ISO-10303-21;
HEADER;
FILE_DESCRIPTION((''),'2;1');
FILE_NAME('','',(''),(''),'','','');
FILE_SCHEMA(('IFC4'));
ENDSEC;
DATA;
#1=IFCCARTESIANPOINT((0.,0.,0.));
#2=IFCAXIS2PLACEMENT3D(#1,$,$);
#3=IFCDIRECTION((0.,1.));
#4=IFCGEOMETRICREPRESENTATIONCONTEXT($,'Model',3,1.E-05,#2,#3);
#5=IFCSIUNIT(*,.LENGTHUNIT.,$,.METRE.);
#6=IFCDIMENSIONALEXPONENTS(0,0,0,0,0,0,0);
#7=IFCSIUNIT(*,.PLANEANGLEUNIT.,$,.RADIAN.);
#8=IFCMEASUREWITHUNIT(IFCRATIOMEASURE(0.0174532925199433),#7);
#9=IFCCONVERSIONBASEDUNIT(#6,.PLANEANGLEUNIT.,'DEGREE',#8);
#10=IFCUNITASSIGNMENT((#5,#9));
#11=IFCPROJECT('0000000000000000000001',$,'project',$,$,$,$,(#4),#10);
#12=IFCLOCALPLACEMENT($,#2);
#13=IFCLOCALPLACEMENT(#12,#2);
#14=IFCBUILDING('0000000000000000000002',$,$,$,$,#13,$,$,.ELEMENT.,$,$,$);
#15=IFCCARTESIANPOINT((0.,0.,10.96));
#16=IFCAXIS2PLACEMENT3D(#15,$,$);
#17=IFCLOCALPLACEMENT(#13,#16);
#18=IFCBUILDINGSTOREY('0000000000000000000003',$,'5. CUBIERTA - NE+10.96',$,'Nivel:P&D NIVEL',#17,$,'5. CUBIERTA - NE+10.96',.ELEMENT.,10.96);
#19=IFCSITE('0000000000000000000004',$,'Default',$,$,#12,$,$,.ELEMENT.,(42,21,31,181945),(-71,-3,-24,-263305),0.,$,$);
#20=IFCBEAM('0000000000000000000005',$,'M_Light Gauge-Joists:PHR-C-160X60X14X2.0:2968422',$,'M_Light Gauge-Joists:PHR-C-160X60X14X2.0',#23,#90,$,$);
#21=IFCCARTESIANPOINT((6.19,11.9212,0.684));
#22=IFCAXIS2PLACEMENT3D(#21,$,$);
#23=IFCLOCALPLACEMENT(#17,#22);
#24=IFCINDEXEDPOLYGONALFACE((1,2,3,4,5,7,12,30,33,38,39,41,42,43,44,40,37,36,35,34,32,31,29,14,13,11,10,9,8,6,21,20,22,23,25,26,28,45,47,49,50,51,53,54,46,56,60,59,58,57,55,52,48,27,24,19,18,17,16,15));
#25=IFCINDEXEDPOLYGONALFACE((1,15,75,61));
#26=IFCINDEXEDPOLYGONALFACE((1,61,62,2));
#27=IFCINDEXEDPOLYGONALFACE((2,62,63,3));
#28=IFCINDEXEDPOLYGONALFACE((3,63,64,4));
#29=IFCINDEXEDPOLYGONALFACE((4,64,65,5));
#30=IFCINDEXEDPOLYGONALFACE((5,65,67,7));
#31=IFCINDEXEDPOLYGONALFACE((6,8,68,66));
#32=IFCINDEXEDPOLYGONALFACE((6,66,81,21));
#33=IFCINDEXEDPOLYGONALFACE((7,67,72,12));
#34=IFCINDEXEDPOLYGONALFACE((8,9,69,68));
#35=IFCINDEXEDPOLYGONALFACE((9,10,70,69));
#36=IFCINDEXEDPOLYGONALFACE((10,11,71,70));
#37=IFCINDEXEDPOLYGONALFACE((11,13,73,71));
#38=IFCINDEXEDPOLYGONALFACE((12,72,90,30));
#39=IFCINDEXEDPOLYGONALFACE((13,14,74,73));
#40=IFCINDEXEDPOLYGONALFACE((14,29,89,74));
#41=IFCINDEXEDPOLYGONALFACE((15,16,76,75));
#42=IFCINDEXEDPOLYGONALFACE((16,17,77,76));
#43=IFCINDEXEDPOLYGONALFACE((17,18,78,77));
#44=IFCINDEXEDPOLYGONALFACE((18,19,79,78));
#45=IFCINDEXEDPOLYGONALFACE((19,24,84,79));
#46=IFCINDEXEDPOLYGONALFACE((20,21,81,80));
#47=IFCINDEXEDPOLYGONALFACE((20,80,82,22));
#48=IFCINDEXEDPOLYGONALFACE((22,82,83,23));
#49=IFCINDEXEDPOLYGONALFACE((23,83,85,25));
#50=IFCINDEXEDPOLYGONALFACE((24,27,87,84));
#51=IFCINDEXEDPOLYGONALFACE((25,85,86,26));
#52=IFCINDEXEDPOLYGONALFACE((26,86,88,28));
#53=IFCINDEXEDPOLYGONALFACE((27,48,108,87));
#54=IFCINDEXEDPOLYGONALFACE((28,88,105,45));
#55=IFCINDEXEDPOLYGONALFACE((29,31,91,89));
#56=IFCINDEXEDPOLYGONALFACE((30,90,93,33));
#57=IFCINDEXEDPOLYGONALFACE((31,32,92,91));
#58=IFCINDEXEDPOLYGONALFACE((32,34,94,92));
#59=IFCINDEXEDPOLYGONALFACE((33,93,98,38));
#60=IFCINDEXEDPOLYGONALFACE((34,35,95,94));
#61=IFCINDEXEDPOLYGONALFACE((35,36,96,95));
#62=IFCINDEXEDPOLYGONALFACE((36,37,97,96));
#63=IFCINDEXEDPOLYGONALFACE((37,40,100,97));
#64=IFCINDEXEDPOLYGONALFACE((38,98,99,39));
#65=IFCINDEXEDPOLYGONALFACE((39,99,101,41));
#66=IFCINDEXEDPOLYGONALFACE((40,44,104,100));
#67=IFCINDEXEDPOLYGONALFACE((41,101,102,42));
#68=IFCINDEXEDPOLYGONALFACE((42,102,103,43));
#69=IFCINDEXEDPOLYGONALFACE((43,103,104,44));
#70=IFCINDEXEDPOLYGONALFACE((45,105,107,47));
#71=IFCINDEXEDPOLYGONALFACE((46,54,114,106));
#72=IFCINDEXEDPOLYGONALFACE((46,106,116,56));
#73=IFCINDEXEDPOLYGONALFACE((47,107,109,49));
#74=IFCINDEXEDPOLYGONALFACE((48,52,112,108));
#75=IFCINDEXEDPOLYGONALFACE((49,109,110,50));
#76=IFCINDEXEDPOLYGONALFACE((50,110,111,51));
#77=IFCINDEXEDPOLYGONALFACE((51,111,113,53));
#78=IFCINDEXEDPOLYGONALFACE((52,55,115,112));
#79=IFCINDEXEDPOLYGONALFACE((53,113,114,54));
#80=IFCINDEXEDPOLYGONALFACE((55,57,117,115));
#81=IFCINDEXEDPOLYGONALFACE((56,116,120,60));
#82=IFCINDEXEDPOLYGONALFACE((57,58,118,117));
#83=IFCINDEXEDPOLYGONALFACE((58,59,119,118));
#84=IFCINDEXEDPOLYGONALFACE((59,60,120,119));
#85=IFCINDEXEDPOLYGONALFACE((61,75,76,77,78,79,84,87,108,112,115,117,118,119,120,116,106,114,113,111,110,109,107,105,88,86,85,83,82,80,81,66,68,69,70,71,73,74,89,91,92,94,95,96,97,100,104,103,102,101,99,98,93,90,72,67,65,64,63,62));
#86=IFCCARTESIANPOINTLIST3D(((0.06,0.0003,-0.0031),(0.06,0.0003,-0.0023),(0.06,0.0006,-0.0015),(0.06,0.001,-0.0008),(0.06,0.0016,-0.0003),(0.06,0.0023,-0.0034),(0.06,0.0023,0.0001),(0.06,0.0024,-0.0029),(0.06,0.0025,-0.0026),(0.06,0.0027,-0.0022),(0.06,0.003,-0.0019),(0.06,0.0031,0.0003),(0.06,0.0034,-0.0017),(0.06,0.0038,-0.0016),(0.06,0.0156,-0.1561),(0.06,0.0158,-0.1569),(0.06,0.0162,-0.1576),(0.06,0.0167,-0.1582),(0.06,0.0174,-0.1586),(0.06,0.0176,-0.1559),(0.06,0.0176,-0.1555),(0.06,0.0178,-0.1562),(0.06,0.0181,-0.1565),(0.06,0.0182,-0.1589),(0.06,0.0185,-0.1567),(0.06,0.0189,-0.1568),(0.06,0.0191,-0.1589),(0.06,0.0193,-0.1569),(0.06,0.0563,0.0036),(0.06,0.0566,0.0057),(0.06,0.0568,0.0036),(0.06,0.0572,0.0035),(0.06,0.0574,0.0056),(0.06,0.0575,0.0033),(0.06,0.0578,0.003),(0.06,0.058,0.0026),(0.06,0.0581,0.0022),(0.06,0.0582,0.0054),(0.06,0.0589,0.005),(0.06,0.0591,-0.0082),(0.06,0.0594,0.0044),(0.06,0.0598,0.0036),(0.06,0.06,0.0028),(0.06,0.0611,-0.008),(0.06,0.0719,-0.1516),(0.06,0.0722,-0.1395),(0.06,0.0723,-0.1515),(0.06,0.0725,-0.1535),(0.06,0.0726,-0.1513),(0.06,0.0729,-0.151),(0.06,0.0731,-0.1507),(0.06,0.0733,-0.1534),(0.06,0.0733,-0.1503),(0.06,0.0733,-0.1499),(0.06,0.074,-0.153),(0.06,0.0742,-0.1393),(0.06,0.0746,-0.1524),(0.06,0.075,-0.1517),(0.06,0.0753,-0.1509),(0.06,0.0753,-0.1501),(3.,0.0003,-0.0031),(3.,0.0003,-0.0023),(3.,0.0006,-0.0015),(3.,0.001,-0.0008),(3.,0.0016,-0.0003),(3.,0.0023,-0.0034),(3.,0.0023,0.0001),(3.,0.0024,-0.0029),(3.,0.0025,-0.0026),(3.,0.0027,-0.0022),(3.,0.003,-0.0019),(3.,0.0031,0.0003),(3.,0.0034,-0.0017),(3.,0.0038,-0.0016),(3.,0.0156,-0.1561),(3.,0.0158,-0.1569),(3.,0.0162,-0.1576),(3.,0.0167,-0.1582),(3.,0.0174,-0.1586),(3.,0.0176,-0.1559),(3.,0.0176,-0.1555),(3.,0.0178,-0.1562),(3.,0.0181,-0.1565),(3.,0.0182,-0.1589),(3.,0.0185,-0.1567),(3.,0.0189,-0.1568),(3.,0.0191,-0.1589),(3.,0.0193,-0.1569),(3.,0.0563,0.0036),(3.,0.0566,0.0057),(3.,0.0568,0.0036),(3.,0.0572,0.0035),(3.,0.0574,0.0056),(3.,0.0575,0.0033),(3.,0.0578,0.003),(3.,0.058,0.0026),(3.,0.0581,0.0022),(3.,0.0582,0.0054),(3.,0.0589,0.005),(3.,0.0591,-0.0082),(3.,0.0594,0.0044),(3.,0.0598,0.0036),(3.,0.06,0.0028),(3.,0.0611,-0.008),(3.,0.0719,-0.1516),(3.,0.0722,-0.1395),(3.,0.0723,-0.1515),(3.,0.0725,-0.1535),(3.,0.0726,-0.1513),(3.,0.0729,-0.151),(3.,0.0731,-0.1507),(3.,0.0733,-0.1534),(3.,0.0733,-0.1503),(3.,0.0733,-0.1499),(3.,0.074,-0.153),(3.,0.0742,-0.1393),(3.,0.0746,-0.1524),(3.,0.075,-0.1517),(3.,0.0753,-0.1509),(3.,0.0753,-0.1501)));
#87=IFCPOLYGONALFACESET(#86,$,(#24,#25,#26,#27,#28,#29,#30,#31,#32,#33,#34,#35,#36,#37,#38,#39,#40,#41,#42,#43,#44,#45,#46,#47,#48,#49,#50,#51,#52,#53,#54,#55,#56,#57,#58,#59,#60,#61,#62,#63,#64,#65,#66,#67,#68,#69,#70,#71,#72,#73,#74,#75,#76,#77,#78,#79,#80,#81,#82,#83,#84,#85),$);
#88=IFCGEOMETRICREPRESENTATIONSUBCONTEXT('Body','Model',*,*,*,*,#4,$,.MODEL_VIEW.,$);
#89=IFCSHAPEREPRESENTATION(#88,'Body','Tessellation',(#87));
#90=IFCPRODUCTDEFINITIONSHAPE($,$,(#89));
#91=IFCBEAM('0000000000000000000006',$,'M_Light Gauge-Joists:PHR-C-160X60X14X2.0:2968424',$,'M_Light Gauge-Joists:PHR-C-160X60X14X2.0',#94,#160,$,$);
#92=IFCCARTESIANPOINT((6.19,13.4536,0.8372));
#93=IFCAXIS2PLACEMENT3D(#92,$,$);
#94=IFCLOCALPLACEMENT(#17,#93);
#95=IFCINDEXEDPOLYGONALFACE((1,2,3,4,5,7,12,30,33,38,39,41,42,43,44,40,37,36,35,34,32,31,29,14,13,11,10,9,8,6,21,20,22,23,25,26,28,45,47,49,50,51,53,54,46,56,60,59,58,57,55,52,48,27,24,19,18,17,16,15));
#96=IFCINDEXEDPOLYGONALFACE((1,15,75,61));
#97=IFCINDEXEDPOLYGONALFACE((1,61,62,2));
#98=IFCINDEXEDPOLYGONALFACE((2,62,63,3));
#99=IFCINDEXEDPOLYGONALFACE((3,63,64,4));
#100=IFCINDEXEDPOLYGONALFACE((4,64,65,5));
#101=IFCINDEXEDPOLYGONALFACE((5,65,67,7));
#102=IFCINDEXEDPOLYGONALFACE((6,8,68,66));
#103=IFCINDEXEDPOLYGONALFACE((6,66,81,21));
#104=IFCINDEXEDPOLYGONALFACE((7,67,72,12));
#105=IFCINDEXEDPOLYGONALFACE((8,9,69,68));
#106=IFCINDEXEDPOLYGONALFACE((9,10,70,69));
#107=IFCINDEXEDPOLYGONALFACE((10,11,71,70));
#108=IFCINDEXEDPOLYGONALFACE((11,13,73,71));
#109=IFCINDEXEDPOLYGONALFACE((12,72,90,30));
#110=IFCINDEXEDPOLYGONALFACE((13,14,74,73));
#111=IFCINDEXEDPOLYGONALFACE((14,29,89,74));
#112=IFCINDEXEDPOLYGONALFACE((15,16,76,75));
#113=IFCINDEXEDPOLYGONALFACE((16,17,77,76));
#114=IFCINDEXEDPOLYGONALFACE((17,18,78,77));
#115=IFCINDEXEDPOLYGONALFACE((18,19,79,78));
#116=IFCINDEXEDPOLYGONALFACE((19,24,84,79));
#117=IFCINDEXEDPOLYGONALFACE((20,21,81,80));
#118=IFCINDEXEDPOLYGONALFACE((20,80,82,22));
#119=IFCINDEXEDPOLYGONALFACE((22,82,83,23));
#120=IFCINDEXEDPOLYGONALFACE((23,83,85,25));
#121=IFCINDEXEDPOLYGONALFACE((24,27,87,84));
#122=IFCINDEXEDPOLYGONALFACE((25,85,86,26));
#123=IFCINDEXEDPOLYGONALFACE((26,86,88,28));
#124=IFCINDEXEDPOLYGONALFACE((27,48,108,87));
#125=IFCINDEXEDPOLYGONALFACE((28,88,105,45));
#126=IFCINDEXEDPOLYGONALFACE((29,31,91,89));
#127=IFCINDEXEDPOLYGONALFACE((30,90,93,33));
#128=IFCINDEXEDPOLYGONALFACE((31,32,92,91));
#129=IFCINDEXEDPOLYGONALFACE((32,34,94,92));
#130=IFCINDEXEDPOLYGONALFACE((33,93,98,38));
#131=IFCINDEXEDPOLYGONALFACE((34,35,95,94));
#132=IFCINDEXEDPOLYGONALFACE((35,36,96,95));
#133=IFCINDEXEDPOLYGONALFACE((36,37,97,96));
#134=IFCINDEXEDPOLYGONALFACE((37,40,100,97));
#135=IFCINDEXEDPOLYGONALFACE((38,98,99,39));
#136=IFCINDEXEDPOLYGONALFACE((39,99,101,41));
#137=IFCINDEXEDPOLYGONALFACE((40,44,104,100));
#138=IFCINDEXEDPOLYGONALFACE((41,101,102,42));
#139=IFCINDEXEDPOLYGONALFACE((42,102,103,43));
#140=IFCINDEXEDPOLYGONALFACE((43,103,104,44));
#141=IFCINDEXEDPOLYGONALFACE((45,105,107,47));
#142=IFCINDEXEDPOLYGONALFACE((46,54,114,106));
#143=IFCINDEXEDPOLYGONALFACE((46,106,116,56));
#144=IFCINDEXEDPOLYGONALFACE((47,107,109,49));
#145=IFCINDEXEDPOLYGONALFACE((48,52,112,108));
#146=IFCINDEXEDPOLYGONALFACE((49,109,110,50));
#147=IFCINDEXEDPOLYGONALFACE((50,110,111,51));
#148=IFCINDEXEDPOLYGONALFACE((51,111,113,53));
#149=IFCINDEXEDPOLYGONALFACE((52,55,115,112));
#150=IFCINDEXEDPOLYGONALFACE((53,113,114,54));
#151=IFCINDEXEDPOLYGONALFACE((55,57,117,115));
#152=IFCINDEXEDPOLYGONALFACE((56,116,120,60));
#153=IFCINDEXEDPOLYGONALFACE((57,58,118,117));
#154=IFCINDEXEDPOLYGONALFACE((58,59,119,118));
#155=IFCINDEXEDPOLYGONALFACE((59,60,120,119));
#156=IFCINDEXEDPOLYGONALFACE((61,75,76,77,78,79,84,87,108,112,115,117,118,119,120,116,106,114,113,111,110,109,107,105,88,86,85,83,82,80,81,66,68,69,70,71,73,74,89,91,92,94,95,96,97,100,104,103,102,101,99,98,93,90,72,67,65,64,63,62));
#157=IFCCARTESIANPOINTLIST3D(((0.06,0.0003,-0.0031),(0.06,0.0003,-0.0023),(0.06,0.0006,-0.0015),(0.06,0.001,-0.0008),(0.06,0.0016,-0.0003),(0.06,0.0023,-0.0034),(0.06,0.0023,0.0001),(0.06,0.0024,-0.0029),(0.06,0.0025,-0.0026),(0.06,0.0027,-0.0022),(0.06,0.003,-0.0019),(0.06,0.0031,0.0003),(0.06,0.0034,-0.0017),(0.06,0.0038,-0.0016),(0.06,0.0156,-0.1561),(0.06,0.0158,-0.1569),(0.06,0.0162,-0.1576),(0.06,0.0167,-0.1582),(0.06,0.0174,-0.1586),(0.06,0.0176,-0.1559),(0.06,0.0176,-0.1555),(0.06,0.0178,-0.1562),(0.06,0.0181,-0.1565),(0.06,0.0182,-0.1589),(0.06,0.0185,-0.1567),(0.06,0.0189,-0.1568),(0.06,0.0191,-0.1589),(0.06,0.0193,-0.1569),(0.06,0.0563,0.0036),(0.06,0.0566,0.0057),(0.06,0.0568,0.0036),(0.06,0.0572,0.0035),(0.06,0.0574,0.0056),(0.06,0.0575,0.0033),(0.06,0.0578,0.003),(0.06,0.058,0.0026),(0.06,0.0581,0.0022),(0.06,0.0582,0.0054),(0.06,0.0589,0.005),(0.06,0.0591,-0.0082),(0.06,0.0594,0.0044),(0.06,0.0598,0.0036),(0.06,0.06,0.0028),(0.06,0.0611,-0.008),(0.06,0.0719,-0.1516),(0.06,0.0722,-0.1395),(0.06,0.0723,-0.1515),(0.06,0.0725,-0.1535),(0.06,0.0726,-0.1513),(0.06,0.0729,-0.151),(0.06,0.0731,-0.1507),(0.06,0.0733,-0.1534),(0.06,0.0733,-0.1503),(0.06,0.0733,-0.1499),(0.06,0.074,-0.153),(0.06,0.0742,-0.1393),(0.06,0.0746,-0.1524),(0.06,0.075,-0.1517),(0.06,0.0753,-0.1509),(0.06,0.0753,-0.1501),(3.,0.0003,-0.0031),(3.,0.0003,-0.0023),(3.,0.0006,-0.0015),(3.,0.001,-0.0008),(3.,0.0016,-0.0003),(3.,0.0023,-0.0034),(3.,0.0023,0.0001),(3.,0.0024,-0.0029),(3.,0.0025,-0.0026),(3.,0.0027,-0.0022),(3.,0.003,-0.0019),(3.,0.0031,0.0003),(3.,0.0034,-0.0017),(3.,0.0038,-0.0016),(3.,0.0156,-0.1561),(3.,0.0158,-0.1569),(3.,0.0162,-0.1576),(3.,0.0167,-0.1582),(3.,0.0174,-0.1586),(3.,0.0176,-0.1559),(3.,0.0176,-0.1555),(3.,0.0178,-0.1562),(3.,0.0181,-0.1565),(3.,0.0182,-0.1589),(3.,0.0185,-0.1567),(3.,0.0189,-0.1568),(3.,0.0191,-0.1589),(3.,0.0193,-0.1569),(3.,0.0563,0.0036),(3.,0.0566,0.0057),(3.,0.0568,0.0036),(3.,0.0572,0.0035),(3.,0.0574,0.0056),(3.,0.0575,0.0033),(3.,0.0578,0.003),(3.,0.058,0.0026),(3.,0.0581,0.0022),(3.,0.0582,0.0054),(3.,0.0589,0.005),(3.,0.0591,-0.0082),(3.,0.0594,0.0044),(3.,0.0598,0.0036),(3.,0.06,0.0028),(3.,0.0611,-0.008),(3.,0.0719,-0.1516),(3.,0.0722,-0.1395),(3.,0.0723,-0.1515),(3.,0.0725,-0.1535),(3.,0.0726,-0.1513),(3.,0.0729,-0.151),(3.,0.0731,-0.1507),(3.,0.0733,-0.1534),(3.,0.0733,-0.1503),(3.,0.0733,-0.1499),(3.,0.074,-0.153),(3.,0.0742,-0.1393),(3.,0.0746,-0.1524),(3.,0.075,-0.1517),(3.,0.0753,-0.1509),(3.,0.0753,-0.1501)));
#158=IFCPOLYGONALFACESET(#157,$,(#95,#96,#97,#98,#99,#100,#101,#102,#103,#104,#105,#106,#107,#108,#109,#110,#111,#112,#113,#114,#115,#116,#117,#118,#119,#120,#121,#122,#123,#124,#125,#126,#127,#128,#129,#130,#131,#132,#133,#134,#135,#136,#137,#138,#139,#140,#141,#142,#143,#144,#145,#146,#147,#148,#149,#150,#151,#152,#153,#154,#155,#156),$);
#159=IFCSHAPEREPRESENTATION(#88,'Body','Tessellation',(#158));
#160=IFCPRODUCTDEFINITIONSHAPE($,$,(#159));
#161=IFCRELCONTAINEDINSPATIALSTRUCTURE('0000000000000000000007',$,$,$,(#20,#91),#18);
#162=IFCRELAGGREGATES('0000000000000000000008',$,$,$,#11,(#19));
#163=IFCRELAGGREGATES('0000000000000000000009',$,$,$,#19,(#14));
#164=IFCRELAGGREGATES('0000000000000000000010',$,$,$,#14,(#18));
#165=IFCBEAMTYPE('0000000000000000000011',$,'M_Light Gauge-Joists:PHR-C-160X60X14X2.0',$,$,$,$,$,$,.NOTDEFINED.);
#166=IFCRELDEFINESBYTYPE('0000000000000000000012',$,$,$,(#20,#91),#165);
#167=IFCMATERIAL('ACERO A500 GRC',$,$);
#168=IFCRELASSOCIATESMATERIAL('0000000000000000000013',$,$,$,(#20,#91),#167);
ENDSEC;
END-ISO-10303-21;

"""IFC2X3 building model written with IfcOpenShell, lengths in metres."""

from ifc_helpers import new_model, entity, si_unit, converted_unit, direction, frame, frame_2d, origin, place, context, subcontext, project, spatial, polyline, circle_curve, parameter, trimmed, segment, composite_curve, outline, extrude, material, type_object, element, save


model = new_model("IFC2X3")

# Units and contexts
model_context = context("Model", 3, precision=1e-05, world=origin(), true_north=direction((0.0, 1.0)))
body_context = subcontext(model_context, "Body", "Model", "MODEL_VIEW")
ifc_project = project(units=[si_unit("LENGTHUNIT", "METRE"), converted_unit("PLANEANGLEUNIT", "DEGREE", entity("IfcRatioMeasure", 0.0174532925199433), si_unit("PLANEANGLEUNIT", "RADIAN"), dimensions=[0, 0, 0, 0, 0, 0, 0])], contexts=[model_context])

# Site, building, storey
site_placement = place(None, origin())
site = spatial("IfcSite", under=ifc_project, at=site_placement, Name="Default", CompositionType="ELEMENT", RefLatitude=(42, 21, 31, 181945), RefLongitude=(-71, -3, -24, -263305), RefElevation=0.0)
building_placement = place(site_placement, origin())
building = spatial("IfcBuilding", under=site, at=building_placement, CompositionType="ELEMENT")
storey_placement = place(building_placement, frame((0.0, 0.0, 10.96)))
storey = spatial("IfcBuildingStorey", under=building, at=storey_placement, Name="5. CUBIERTA - NE+10.96", ObjectType="Nivel:P&D NIVEL", LongName="5. CUBIERTA - NE+10.96", CompositionType="ELEMENT", Elevation=10.96)

# Beams
ifc_material_1 = material(Name="ACERO A500 GRC")
beam_type_1 = type_object("IfcBeamType", Name="M_Light Gauge-Joists:PHR-C-160X60X14X2.0", PredefinedType="NOTDEFINED")
beam_1_placement = place(storey_placement, frame((6.19, 11.9212, 0.684)))
element("IfcBeam", 1, at=beam_1_placement, inside=storey, type_object=beam_type_1, material=ifc_material_1, Name="M_Light Gauge-Joists:PHR-C-160X60X14X2.0:2968422", ObjectType="M_Light Gauge-Joists:PHR-C-160X60X14X2.0", context=body_context, shape_type="SweptSolid", body=[
    extrude(outline(composite_curve([segment(trimmed(circle_curve(frame_2d((-0.0764, -0.0322), x_axis=(-1.0, 0.0)), 0.0016), [parameter(0.0)], [parameter(90.0)], True, "PARAMETER"), False, "CONTINUOUS"), segment(polyline([(-0.078, -0.0322), (-0.078, 0.0206)]), True, "CONTINUOUS"), segment(trimmed(circle_curve(frame_2d((-0.0764, 0.0206), x_axis=(0.0, 1.0)), 0.0016), [parameter(0.0)], [parameter(90.0)], True, "PARAMETER"), False, "CONTINUOUS"), segment(polyline([(-0.0764, 0.0222), (-0.066, 0.0222)]), True, "CONTINUOUS"), segment(polyline([(-0.066, 0.0222), (-0.066, 0.0242)]), True, "CONTINUOUS"), segment(polyline([(-0.066, 0.0242), (-0.0768, 0.0242)]), True, "CONTINUOUS"), segment(trimmed(circle_curve(frame_2d((-0.0768, 0.021), x_axis=(-1.0, 0.0)), 0.0032), [parameter(270.0)], [parameter(0.0)], True, "PARAMETER"), True, "CONTINUOUS"), segment(polyline([(-0.08, 0.021), (-0.08, -0.0326)]), True, "CONTINUOUS"), segment(trimmed(circle_curve(frame_2d((-0.0768, -0.0326), x_axis=(0.0, -1.0)), 0.0032), [parameter(270.0)], [parameter(0.0)], True, "PARAMETER"), True, "CONTINUOUS"), segment(polyline([(-0.0768, -0.0358), (0.0768, -0.0358)]), True, "CONTINUOUS"), segment(trimmed(circle_curve(frame_2d((0.0768, -0.0326), x_axis=(1.0, 0.0)), 0.0032), [parameter(270.0)], [parameter(0.0)], True, "PARAMETER"), True, "CONTINUOUS"), segment(polyline([(0.08, -0.0326), (0.08, 0.021)]), True, "CONTINUOUS"), segment(trimmed(circle_curve(frame_2d((0.0768, 0.021), x_axis=(0.0, 1.0)), 0.0032), [parameter(270.0)], [parameter(0.0)], True, "PARAMETER"), True, "CONTINUOUS"), segment(polyline([(0.0768, 0.0242), (0.066, 0.0242)]), True, "CONTINUOUS"), segment(polyline([(0.066, 0.0242), (0.066, 0.0222)]), True, "CONTINUOUS"), segment(polyline([(0.066, 0.0222), (0.0764, 0.0222)]), True, "CONTINUOUS"), segment(trimmed(circle_curve(frame_2d((0.0764, 0.0206), x_axis=(1.0, 0.0)), 0.0016), [parameter(0.0)], [parameter(90.0)], True, "PARAMETER"), False, "CONTINUOUS"), segment(polyline([(0.078, 0.0206), (0.078, -0.0322)]), True, "CONTINUOUS"), segment(trimmed(circle_curve(frame_2d((0.0764, -0.0322), x_axis=(0.0, -1.0)), 0.0016), [parameter(0.0)], [parameter(90.0)], True, "PARAMETER"), False, "CONTINUOUS"), segment(polyline([(0.0764, -0.0338), (-0.0764, -0.0338)]), True, "CONTINUOUS")], self_intersect=False)), frame((0.06, 0.0436, -0.076), z_axis=(-1.0, 0.0, 0.0), x_axis=(0.0, -0.099504, 0.995037)), (0.0, 0.0, -1.0), 2.94),
])
beam_2_placement = place(storey_placement, frame((6.19, 13.4536, 0.8372)))
element("IfcBeam", 2, at=beam_2_placement, inside=storey, type_object=beam_type_1, material=ifc_material_1, Name="M_Light Gauge-Joists:PHR-C-160X60X14X2.0:2968424", ObjectType="M_Light Gauge-Joists:PHR-C-160X60X14X2.0", context=body_context, shape_type="SweptSolid", body=[
    extrude(outline(composite_curve([segment(trimmed(circle_curve(frame_2d((-0.0764, -0.0322), x_axis=(-1.0, 0.0)), 0.0016), [parameter(0.0)], [parameter(90.0)], True, "PARAMETER"), False, "CONTINUOUS"), segment(polyline([(-0.078, -0.0322), (-0.078, 0.0206)]), True, "CONTINUOUS"), segment(trimmed(circle_curve(frame_2d((-0.0764, 0.0206), x_axis=(0.0, 1.0)), 0.0016), [parameter(0.0)], [parameter(90.0)], True, "PARAMETER"), False, "CONTINUOUS"), segment(polyline([(-0.0764, 0.0222), (-0.066, 0.0222)]), True, "CONTINUOUS"), segment(polyline([(-0.066, 0.0222), (-0.066, 0.0242)]), True, "CONTINUOUS"), segment(polyline([(-0.066, 0.0242), (-0.0768, 0.0242)]), True, "CONTINUOUS"), segment(trimmed(circle_curve(frame_2d((-0.0768, 0.021), x_axis=(-1.0, 0.0)), 0.0032), [parameter(270.0)], [parameter(0.0)], True, "PARAMETER"), True, "CONTINUOUS"), segment(polyline([(-0.08, 0.021), (-0.08, -0.0326)]), True, "CONTINUOUS"), segment(trimmed(circle_curve(frame_2d((-0.0768, -0.0326), x_axis=(0.0, -1.0)), 0.0032), [parameter(270.0)], [parameter(0.0)], True, "PARAMETER"), True, "CONTINUOUS"), segment(polyline([(-0.0768, -0.0358), (0.0768, -0.0358)]), True, "CONTINUOUS"), segment(trimmed(circle_curve(frame_2d((0.0768, -0.0326), x_axis=(1.0, 0.0)), 0.0032), [parameter(270.0)], [parameter(0.0)], True, "PARAMETER"), True, "CONTINUOUS"), segment(polyline([(0.08, -0.0326), (0.08, 0.021)]), True, "CONTINUOUS"), segment(trimmed(circle_curve(frame_2d((0.0768, 0.021), x_axis=(0.0, 1.0)), 0.0032), [parameter(270.0)], [parameter(0.0)], True, "PARAMETER"), True, "CONTINUOUS"), segment(polyline([(0.0768, 0.0242), (0.066, 0.0242)]), True, "CONTINUOUS"), segment(polyline([(0.066, 0.0242), (0.066, 0.0222)]), True, "CONTINUOUS"), segment(polyline([(0.066, 0.0222), (0.0764, 0.0222)]), True, "CONTINUOUS"), segment(trimmed(circle_curve(frame_2d((0.0764, 0.0206), x_axis=(1.0, 0.0)), 0.0016), [parameter(0.0)], [parameter(90.0)], True, "PARAMETER"), False, "CONTINUOUS"), segment(polyline([(0.078, 0.0206), (0.078, -0.0322)]), True, "CONTINUOUS"), segment(trimmed(circle_curve(frame_2d((0.0764, -0.0322), x_axis=(0.0, -1.0)), 0.0016), [parameter(0.0)], [parameter(90.0)], True, "PARAMETER"), False, "CONTINUOUS"), segment(polyline([(0.0764, -0.0338), (-0.0764, -0.0338)]), True, "CONTINUOUS")], self_intersect=False)), frame((0.06, 0.0436, -0.076), z_axis=(-1.0, 0.0, 0.0), x_axis=(0.0, -0.099504, 0.995037)), (0.0, 0.0, -1.0), 2.94),
])

save(model, "model.ifc")
